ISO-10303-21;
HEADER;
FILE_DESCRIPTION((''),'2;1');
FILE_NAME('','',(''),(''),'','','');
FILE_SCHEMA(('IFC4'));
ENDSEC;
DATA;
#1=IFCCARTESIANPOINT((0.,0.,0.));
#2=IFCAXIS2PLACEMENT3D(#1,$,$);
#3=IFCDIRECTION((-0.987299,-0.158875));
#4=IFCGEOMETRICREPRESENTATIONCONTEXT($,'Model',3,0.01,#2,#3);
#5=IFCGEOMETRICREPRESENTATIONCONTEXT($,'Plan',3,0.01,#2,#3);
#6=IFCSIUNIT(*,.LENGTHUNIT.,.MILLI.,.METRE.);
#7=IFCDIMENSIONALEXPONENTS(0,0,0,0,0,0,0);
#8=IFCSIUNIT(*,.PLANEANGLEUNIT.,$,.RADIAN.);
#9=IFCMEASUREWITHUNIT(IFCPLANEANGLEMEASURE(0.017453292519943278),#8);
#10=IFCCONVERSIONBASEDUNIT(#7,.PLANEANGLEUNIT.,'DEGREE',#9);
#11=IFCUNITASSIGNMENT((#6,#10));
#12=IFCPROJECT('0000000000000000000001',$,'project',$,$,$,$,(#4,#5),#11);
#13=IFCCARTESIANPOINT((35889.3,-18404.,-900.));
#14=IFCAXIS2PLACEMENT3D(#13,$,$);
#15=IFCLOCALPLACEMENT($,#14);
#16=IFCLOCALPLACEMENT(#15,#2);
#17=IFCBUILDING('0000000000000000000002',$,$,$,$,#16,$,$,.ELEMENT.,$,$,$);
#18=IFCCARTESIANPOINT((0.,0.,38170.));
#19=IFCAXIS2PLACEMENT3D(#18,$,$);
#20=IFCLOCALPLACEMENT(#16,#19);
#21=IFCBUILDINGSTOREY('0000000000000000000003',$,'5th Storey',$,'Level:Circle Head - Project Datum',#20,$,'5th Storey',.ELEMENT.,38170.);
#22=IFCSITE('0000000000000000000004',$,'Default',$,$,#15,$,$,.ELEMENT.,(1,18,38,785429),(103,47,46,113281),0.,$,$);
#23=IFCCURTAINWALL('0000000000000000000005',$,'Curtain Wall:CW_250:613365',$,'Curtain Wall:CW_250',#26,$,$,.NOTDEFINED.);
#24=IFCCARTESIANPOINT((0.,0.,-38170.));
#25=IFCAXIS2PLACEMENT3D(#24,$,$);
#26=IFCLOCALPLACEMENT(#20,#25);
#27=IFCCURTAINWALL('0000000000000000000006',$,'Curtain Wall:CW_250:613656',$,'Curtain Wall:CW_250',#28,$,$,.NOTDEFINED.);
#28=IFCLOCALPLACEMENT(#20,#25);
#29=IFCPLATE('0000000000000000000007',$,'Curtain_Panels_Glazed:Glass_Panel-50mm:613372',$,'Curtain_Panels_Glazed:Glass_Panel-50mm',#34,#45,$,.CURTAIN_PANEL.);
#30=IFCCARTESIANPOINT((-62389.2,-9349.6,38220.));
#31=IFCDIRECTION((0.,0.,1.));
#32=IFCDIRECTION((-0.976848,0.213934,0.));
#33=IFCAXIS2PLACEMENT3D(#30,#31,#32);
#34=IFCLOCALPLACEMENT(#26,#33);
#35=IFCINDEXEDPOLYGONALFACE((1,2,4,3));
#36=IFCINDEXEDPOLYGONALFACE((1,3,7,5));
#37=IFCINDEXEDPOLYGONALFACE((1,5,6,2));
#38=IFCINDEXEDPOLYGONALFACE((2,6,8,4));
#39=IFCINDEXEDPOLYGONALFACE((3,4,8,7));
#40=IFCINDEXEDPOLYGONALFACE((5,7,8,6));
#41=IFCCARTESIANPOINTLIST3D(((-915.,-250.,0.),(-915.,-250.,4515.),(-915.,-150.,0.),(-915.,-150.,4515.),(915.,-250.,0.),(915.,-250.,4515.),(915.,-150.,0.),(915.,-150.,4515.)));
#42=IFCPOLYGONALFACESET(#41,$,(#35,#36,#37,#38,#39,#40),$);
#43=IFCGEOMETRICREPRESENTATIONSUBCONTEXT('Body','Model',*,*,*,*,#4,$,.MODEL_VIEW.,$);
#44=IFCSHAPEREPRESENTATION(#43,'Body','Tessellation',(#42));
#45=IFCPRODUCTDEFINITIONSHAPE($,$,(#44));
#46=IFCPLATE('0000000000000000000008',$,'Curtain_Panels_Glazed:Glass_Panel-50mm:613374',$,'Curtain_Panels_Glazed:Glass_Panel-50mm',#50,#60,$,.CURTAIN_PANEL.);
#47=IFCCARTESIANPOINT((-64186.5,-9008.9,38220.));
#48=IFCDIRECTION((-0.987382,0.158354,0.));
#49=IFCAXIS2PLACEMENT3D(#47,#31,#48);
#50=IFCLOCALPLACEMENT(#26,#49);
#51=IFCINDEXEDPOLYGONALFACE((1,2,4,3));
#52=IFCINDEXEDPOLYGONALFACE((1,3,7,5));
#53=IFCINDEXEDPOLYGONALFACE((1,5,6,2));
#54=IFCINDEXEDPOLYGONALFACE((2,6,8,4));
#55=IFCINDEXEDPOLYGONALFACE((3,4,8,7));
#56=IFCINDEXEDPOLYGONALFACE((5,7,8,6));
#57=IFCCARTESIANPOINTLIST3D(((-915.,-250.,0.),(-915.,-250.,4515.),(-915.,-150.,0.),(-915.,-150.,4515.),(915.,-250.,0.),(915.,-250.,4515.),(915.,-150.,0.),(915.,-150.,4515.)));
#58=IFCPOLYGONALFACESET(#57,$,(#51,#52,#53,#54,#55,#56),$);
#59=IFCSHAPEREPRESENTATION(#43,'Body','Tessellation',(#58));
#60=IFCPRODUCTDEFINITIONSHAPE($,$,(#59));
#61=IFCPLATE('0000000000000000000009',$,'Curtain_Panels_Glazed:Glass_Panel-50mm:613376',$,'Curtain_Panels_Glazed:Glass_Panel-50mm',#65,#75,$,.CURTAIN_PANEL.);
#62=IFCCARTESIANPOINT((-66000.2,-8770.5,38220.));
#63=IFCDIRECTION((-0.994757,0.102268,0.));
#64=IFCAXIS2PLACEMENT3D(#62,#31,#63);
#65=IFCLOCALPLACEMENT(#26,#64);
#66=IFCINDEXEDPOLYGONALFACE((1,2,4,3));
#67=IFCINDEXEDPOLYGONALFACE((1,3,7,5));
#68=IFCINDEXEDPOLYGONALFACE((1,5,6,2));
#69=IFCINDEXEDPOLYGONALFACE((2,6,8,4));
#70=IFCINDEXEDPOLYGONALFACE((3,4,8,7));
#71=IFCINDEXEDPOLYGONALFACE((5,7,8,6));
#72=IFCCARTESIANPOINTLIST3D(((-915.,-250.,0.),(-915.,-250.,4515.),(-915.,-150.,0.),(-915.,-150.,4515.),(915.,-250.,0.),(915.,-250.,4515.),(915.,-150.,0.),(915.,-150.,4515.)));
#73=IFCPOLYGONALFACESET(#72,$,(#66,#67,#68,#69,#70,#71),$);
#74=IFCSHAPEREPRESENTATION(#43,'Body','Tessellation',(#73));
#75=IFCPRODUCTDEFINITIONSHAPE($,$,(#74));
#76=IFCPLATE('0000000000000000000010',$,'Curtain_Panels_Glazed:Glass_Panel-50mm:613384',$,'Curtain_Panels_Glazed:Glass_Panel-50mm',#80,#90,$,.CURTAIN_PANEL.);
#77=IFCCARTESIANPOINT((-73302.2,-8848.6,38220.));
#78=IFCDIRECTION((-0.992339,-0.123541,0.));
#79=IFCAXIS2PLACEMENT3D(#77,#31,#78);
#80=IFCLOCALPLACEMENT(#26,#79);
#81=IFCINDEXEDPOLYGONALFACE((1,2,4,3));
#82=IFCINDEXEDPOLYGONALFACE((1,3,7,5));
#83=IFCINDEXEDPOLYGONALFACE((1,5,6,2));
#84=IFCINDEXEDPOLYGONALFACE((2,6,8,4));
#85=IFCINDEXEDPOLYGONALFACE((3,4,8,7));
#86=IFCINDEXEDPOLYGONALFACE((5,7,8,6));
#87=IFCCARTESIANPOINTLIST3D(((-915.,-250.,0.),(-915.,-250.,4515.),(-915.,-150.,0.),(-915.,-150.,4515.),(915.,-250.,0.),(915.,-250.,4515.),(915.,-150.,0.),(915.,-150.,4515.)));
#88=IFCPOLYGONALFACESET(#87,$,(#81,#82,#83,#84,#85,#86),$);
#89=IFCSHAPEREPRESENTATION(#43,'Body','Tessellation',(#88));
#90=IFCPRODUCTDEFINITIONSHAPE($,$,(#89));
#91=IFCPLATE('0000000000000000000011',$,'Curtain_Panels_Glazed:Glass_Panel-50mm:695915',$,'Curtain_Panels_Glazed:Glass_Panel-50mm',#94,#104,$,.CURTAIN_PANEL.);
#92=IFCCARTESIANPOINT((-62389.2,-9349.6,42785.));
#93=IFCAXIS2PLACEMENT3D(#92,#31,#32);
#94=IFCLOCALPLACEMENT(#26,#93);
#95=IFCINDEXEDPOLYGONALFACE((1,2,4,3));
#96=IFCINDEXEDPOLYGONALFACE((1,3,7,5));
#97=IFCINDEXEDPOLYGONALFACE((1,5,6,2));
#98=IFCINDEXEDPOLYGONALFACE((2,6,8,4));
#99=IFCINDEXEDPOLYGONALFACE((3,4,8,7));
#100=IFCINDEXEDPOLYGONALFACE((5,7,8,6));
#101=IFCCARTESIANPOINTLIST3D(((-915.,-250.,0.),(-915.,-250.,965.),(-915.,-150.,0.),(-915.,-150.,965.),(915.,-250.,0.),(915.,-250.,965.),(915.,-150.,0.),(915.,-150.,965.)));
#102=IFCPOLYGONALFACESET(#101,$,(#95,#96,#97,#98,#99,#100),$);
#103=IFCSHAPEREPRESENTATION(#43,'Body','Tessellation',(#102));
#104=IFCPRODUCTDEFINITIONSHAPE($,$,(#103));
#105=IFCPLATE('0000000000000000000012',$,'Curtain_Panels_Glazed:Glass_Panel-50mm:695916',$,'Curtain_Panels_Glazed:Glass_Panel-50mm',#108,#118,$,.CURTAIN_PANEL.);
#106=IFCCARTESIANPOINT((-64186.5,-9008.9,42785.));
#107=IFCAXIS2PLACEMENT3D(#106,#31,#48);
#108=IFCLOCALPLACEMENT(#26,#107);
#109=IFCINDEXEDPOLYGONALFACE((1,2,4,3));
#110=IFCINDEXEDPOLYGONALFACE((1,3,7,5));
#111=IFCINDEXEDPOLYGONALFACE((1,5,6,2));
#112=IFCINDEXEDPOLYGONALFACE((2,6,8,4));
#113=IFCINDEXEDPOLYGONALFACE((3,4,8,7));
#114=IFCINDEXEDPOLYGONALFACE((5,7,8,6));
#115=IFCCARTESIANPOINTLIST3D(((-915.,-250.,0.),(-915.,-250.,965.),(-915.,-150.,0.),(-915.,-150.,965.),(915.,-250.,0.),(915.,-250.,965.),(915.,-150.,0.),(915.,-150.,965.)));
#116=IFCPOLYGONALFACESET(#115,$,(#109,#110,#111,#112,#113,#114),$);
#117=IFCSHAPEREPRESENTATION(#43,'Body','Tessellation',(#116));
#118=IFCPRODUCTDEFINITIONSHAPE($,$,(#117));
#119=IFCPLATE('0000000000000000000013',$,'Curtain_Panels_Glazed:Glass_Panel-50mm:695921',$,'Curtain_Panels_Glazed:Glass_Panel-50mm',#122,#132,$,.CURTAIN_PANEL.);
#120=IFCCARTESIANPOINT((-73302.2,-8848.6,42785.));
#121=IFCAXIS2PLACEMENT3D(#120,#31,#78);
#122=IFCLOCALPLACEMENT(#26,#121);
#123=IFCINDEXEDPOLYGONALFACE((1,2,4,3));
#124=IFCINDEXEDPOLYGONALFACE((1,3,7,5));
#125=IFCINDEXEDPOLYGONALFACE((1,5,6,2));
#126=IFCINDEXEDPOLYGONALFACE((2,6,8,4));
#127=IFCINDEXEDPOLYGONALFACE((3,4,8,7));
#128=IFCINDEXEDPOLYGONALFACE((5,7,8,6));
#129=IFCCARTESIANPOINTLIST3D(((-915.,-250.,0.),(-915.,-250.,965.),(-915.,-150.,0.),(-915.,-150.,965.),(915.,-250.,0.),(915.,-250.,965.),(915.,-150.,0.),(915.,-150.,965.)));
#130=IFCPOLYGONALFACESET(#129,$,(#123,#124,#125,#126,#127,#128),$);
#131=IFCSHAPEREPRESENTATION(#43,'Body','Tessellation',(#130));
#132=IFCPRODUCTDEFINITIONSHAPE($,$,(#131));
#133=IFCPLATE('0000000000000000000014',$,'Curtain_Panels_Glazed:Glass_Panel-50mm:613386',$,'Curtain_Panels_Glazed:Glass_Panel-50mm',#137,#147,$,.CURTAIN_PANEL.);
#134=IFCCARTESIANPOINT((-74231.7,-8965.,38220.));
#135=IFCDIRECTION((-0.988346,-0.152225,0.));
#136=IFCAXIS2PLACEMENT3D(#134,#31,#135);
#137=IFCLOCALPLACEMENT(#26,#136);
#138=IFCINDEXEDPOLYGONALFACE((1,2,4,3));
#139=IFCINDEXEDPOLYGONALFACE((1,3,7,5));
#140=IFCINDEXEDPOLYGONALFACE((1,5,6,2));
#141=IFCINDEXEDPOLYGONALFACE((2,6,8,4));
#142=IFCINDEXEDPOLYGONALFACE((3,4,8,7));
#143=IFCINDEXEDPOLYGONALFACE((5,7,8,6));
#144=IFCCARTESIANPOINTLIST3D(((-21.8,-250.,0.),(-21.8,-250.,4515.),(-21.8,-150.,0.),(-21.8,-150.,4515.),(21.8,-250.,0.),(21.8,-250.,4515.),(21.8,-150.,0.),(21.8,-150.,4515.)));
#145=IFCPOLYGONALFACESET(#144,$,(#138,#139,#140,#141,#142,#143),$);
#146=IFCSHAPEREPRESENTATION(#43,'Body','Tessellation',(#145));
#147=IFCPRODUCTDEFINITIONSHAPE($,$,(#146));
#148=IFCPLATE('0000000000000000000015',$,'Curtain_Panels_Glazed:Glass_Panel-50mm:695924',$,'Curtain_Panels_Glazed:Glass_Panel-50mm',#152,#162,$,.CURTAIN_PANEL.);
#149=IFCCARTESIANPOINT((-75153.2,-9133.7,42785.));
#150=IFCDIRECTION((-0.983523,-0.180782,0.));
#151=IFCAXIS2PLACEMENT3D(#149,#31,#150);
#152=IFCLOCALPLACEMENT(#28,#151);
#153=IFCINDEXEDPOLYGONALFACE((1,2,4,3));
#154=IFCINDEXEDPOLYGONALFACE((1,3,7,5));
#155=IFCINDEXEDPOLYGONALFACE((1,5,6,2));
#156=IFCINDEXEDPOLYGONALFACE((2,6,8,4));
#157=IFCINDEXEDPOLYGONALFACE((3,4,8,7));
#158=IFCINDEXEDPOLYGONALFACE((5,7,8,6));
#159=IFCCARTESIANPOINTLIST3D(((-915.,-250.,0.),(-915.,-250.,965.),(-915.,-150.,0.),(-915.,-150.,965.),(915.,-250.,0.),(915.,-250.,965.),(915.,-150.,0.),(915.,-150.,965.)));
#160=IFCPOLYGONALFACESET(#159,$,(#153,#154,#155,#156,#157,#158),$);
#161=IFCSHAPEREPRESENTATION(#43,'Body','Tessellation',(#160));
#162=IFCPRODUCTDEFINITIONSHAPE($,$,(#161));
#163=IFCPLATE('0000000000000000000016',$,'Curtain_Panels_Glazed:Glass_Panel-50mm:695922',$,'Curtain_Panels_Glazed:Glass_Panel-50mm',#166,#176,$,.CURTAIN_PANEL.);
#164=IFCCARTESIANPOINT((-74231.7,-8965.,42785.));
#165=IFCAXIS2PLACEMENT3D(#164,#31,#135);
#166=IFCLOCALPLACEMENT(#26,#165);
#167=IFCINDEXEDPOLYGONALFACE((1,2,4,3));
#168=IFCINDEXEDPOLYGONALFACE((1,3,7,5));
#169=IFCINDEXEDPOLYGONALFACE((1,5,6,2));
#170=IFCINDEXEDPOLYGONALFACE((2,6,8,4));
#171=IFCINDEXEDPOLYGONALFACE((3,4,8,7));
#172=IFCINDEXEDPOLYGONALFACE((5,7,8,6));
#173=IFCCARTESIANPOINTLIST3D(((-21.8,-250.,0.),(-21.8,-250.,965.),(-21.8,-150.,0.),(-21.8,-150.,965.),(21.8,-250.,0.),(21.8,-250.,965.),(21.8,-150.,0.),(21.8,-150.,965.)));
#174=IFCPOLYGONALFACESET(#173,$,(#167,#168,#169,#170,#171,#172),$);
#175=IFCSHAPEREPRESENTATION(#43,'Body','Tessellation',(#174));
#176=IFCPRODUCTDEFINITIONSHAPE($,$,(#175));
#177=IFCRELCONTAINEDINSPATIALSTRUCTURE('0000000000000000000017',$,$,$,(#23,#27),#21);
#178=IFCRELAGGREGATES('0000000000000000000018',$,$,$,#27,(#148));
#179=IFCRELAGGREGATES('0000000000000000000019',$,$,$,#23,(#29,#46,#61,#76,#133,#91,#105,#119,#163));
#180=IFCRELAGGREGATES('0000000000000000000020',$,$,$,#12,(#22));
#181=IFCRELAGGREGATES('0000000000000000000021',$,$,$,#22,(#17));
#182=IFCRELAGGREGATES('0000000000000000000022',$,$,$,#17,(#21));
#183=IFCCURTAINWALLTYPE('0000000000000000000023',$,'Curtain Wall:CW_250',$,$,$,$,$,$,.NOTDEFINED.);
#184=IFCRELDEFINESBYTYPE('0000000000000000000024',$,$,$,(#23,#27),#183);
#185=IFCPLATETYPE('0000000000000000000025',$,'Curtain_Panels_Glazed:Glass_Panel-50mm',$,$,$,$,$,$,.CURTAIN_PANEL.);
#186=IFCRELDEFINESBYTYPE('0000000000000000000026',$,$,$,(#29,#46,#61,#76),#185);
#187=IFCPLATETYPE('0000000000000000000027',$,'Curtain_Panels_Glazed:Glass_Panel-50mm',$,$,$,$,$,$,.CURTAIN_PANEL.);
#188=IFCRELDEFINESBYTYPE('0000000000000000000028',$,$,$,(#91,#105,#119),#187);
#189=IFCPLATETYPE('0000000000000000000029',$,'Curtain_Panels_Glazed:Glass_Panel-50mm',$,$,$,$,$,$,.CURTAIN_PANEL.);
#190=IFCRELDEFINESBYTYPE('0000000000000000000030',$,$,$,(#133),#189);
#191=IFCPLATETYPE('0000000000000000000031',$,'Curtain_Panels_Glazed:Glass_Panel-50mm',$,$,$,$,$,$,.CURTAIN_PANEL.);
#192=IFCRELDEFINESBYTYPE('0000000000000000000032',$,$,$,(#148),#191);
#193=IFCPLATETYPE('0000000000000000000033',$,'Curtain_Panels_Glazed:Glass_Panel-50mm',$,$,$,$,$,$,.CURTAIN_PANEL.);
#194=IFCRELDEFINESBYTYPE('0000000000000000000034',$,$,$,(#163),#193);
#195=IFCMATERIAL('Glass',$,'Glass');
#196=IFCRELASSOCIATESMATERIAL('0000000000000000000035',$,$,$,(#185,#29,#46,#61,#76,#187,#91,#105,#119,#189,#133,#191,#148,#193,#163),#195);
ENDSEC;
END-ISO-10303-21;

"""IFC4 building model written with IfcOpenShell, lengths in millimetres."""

from ifc_helpers import new_model, entity, si_unit, converted_unit, direction, frame, origin, place, context, subcontext, project, spatial, indexed_curve, outline, extrude, source, transform, mapped, material, type_object, type_shapes, element, aggregate, save


model = new_model("IFC4")

# Units and contexts
model_context = context("Model", 3, precision=0.01, world=origin(), true_north=direction((-0.987299, -0.158875)))
plan_context = context("Plan", 3, precision=0.01, world=origin(), true_north=direction((-0.987299, -0.158875)))
body_context = subcontext(model_context, "Body", "Model", "MODEL_VIEW")
ifc_project = project(units=[si_unit("LENGTHUNIT", "METRE", prefix="MILLI"), converted_unit("PLANEANGLEUNIT", "DEGREE", entity("IfcPlaneAngleMeasure", 0.017453292519943278), si_unit("PLANEANGLEUNIT", "RADIAN"), dimensions=[0, 0, 0, 0, 0, 0, 0])], contexts=[model_context, plan_context])

# Site, building, storey
site_placement = place(None, frame((35889.3, -18404.0, -900.0)))
site = spatial("IfcSite", under=ifc_project, at=site_placement, Name="Default", CompositionType="ELEMENT", RefLatitude=(1, 18, 38, 785429), RefLongitude=(103, 47, 46, 113281), RefElevation=0.0)
building_placement = place(site_placement, origin())
building = spatial("IfcBuilding", under=site, at=building_placement, CompositionType="ELEMENT")
storey_placement = place(building_placement, frame((0.0, 0.0, 38170.0)))
storey = spatial("IfcBuildingStorey", under=building, at=storey_placement, Name="5th Storey", ObjectType="Level:Circle Head - Project Datum", LongName="5th Storey", CompositionType="ELEMENT", Elevation=38170.0)

# Curtain wall
curtain_wall_type = type_object("IfcCurtainWallType", Name="Curtain Wall:CW_250", PredefinedType="NOTDEFINED")
curtain_wall_1_placement = place(storey_placement, frame((0.0, 0.0, -38170.0)))
curtain_wall_1 = element("IfcCurtainWall", 1, at=curtain_wall_1_placement, inside=storey, type_object=curtain_wall_type, Name="Curtain Wall:CW_250:613365", ObjectType="Curtain Wall:CW_250", PredefinedType="NOTDEFINED")

# Curtain wall
curtain_wall_2_placement = place(storey_placement, frame((0.0, 0.0, -38170.0)))
curtain_wall_2 = element("IfcCurtainWall", 2, at=curtain_wall_2_placement, inside=storey, type_object=curtain_wall_type, Name="Curtain Wall:CW_250:613656", ObjectType="Curtain Wall:CW_250", PredefinedType="NOTDEFINED")

# Plates
ifc_material_1 = material(Name="Glass", Category="Glass")
plate_type_1 = type_object("IfcPlateType", Name="Curtain_Panels_Glazed:Glass_Panel-50mm", PredefinedType="CURTAIN_PANEL", material=ifc_material_1)
shared_shape_1 = source(origin(), body_context, "Body", "SweptSolid", [
    extrude(outline(indexed_curve([(-915.0, -50.0), (915.0, -50.0), (915.0, 50.0), (-915.0, 50.0), (-915.0, -50.0)], self_intersect=False)), frame((0.0, -200.0, 0.0), z_axis=(0.0, 0.0, 1.0), x_axis=(-1.0, 0.0, 0.0)), (0.0, 0.0, 1.0), 4515.0),
])
type_shapes(plate_type_1, [shared_shape_1])
plate_1_placement = place(curtain_wall_1_placement, frame((-62389.2, -9349.6, 38220.0), z_axis=(0.0, 0.0, 1.0), x_axis=(-0.976848, 0.213934, 0.0)))
plate_1 = element("IfcPlate", 3, at=plate_1_placement, type_object=plate_type_1, material=ifc_material_1, Name="Curtain_Panels_Glazed:Glass_Panel-50mm:613372", ObjectType="Curtain_Panels_Glazed:Glass_Panel-50mm", PredefinedType="CURTAIN_PANEL", context=body_context, shape_type="MappedRepresentation", body=[
    mapped(shared_shape_1, transform((0.0, 0.0, 0.0), scale=1.0)),
])
plate_2_placement = place(curtain_wall_1_placement, frame((-64186.5, -9008.9, 38220.0), z_axis=(0.0, 0.0, 1.0), x_axis=(-0.987382, 0.158354, 0.0)))
plate_2 = element("IfcPlate", 4, at=plate_2_placement, type_object=plate_type_1, material=ifc_material_1, Name="Curtain_Panels_Glazed:Glass_Panel-50mm:613374", ObjectType="Curtain_Panels_Glazed:Glass_Panel-50mm", PredefinedType="CURTAIN_PANEL", context=body_context, shape_type="MappedRepresentation", body=[
    mapped(shared_shape_1, transform((0.0, 0.0, 0.0), scale=1.0)),
])
plate_3_placement = place(curtain_wall_1_placement, frame((-66000.2, -8770.5, 38220.0), z_axis=(0.0, 0.0, 1.0), x_axis=(-0.994757, 0.102268, 0.0)))
plate_3 = element("IfcPlate", 5, at=plate_3_placement, type_object=plate_type_1, material=ifc_material_1, Name="Curtain_Panels_Glazed:Glass_Panel-50mm:613376", ObjectType="Curtain_Panels_Glazed:Glass_Panel-50mm", PredefinedType="CURTAIN_PANEL", context=body_context, shape_type="MappedRepresentation", body=[
    mapped(shared_shape_1, transform((0.0, 0.0, 0.0), scale=1.0)),
])
plate_4_placement = place(curtain_wall_1_placement, frame((-73302.2, -8848.6, 38220.0), z_axis=(0.0, 0.0, 1.0), x_axis=(-0.992339, -0.123541, 0.0)))
plate_4 = element("IfcPlate", 6, at=plate_4_placement, type_object=plate_type_1, material=ifc_material_1, Name="Curtain_Panels_Glazed:Glass_Panel-50mm:613384", ObjectType="Curtain_Panels_Glazed:Glass_Panel-50mm", PredefinedType="CURTAIN_PANEL", context=body_context, shape_type="MappedRepresentation", body=[
    mapped(shared_shape_1, transform((0.0, 0.0, 0.0), scale=1.0)),
])
plate_type_2 = type_object("IfcPlateType", Name="Curtain_Panels_Glazed:Glass_Panel-50mm", PredefinedType="CURTAIN_PANEL", material=ifc_material_1)
shared_shape_2 = source(origin(), body_context, "Body", "SweptSolid", [
    extrude(outline(indexed_curve([(-915.0, -50.0), (915.0, -50.0), (915.0, 50.0), (-915.0, 50.0), (-915.0, -50.0)], self_intersect=False)), frame((0.0, -200.0, 0.0), z_axis=(0.0, 0.0, 1.0), x_axis=(-1.0, 0.0, 0.0)), (0.0, 0.0, 1.0), 965.0),
])
type_shapes(plate_type_2, [shared_shape_2])
plate_5_placement = place(curtain_wall_1_placement, frame((-62389.2, -9349.6, 42785.0), z_axis=(0.0, 0.0, 1.0), x_axis=(-0.976848, 0.213934, 0.0)))
plate_5 = element("IfcPlate", 7, at=plate_5_placement, type_object=plate_type_2, material=ifc_material_1, Name="Curtain_Panels_Glazed:Glass_Panel-50mm:695915", ObjectType="Curtain_Panels_Glazed:Glass_Panel-50mm", PredefinedType="CURTAIN_PANEL", context=body_context, shape_type="MappedRepresentation", body=[
    mapped(shared_shape_2, transform((0.0, 0.0, 0.0), scale=1.0)),
])
plate_6_placement = place(curtain_wall_1_placement, frame((-64186.5, -9008.9, 42785.0), z_axis=(0.0, 0.0, 1.0), x_axis=(-0.987382, 0.158354, 0.0)))
plate_6 = element("IfcPlate", 8, at=plate_6_placement, type_object=plate_type_2, material=ifc_material_1, Name="Curtain_Panels_Glazed:Glass_Panel-50mm:695916", ObjectType="Curtain_Panels_Glazed:Glass_Panel-50mm", PredefinedType="CURTAIN_PANEL", context=body_context, shape_type="MappedRepresentation", body=[
    mapped(shared_shape_2, transform((0.0, 0.0, 0.0), scale=1.0)),
])
plate_7_placement = place(curtain_wall_1_placement, frame((-73302.2, -8848.6, 42785.0), z_axis=(0.0, 0.0, 1.0), x_axis=(-0.992339, -0.123541, 0.0)))
plate_7 = element("IfcPlate", 9, at=plate_7_placement, type_object=plate_type_2, material=ifc_material_1, Name="Curtain_Panels_Glazed:Glass_Panel-50mm:695921", ObjectType="Curtain_Panels_Glazed:Glass_Panel-50mm", PredefinedType="CURTAIN_PANEL", context=body_context, shape_type="MappedRepresentation", body=[
    mapped(shared_shape_2, transform((0.0, 0.0, 0.0), scale=1.0)),
])
plate_type_3 = type_object("IfcPlateType", Name="Curtain_Panels_Glazed:Glass_Panel-50mm", PredefinedType="CURTAIN_PANEL", material=ifc_material_1)
shared_shape_3 = source(origin(), body_context, "Body", "SweptSolid", [
    extrude(outline(indexed_curve([(-21.8, -50.0), (21.8, -50.0), (21.8, 50.0), (-21.8, 50.0), (-21.8, -50.0)], self_intersect=False)), frame((0.0, -200.0, 0.0), z_axis=(0.0, 0.0, 1.0), x_axis=(-1.0, 0.0, 0.0)), (0.0, 0.0, 1.0), 4515.0),
])
type_shapes(plate_type_3, [shared_shape_3])
plate_8_placement = place(curtain_wall_1_placement, frame((-74231.7, -8965.0, 38220.0), z_axis=(0.0, 0.0, 1.0), x_axis=(-0.988346, -0.152225, 0.0)))
plate_8 = element("IfcPlate", 10, at=plate_8_placement, type_object=plate_type_3, material=ifc_material_1, Name="Curtain_Panels_Glazed:Glass_Panel-50mm:613386", ObjectType="Curtain_Panels_Glazed:Glass_Panel-50mm", PredefinedType="CURTAIN_PANEL", context=body_context, shape_type="MappedRepresentation", body=[
    mapped(shared_shape_3, transform((0.0, 0.0, 0.0), scale=1.0)),
])
plate_type_4 = type_object("IfcPlateType", Name="Curtain_Panels_Glazed:Glass_Panel-50mm", PredefinedType="CURTAIN_PANEL", material=ifc_material_1)
shared_shape_4 = source(origin(), body_context, "Body", "SweptSolid", [
    extrude(outline(indexed_curve([(-915.0, -50.0), (915.0, -50.0), (915.0, 50.0), (-915.0, 50.0), (-915.0, -50.0)], self_intersect=False)), frame((0.0, -200.0, 0.0), z_axis=(0.0, 0.0, 1.0), x_axis=(-1.0, 0.0, 0.0)), (0.0, 0.0, 1.0), 965.0),
])
type_shapes(plate_type_4, [shared_shape_4])
plate_9_placement = place(curtain_wall_2_placement, frame((-75153.2, -9133.7, 42785.0), z_axis=(0.0, 0.0, 1.0), x_axis=(-0.983523, -0.180782, 0.0)))
plate_9 = element("IfcPlate", 11, at=plate_9_placement, type_object=plate_type_4, material=ifc_material_1, Name="Curtain_Panels_Glazed:Glass_Panel-50mm:695924", ObjectType="Curtain_Panels_Glazed:Glass_Panel-50mm", PredefinedType="CURTAIN_PANEL", context=body_context, shape_type="MappedRepresentation", body=[
    mapped(shared_shape_4, transform((0.0, 0.0, 0.0), scale=1.0)),
])
aggregate(curtain_wall_2, [plate_9])
plate_type_5 = type_object("IfcPlateType", Name="Curtain_Panels_Glazed:Glass_Panel-50mm", PredefinedType="CURTAIN_PANEL", material=ifc_material_1)
shared_shape_5 = source(origin(), body_context, "Body", "SweptSolid", [
    extrude(outline(indexed_curve([(-21.8, -50.0), (21.8, -50.0), (21.8, 50.0), (-21.8, 50.0), (-21.8, -50.0)], self_intersect=False)), frame((0.0, -200.0, 0.0), z_axis=(0.0, 0.0, 1.0), x_axis=(-1.0, 0.0, 0.0)), (0.0, 0.0, 1.0), 965.0),
])
type_shapes(plate_type_5, [shared_shape_5])
plate_10_placement = place(curtain_wall_1_placement, frame((-74231.7, -8965.0, 42785.0), z_axis=(0.0, 0.0, 1.0), x_axis=(-0.988346, -0.152225, 0.0)))
plate_10 = element("IfcPlate", 12, at=plate_10_placement, type_object=plate_type_5, material=ifc_material_1, Name="Curtain_Panels_Glazed:Glass_Panel-50mm:695922", ObjectType="Curtain_Panels_Glazed:Glass_Panel-50mm", PredefinedType="CURTAIN_PANEL", context=body_context, shape_type="MappedRepresentation", body=[
    mapped(shared_shape_5, transform((0.0, 0.0, 0.0), scale=1.0)),
])
aggregate(curtain_wall_1, [plate_1, plate_2, plate_3, plate_4, plate_8, plate_5, plate_6, plate_7, plate_10])

save(model, "model.ifc")
